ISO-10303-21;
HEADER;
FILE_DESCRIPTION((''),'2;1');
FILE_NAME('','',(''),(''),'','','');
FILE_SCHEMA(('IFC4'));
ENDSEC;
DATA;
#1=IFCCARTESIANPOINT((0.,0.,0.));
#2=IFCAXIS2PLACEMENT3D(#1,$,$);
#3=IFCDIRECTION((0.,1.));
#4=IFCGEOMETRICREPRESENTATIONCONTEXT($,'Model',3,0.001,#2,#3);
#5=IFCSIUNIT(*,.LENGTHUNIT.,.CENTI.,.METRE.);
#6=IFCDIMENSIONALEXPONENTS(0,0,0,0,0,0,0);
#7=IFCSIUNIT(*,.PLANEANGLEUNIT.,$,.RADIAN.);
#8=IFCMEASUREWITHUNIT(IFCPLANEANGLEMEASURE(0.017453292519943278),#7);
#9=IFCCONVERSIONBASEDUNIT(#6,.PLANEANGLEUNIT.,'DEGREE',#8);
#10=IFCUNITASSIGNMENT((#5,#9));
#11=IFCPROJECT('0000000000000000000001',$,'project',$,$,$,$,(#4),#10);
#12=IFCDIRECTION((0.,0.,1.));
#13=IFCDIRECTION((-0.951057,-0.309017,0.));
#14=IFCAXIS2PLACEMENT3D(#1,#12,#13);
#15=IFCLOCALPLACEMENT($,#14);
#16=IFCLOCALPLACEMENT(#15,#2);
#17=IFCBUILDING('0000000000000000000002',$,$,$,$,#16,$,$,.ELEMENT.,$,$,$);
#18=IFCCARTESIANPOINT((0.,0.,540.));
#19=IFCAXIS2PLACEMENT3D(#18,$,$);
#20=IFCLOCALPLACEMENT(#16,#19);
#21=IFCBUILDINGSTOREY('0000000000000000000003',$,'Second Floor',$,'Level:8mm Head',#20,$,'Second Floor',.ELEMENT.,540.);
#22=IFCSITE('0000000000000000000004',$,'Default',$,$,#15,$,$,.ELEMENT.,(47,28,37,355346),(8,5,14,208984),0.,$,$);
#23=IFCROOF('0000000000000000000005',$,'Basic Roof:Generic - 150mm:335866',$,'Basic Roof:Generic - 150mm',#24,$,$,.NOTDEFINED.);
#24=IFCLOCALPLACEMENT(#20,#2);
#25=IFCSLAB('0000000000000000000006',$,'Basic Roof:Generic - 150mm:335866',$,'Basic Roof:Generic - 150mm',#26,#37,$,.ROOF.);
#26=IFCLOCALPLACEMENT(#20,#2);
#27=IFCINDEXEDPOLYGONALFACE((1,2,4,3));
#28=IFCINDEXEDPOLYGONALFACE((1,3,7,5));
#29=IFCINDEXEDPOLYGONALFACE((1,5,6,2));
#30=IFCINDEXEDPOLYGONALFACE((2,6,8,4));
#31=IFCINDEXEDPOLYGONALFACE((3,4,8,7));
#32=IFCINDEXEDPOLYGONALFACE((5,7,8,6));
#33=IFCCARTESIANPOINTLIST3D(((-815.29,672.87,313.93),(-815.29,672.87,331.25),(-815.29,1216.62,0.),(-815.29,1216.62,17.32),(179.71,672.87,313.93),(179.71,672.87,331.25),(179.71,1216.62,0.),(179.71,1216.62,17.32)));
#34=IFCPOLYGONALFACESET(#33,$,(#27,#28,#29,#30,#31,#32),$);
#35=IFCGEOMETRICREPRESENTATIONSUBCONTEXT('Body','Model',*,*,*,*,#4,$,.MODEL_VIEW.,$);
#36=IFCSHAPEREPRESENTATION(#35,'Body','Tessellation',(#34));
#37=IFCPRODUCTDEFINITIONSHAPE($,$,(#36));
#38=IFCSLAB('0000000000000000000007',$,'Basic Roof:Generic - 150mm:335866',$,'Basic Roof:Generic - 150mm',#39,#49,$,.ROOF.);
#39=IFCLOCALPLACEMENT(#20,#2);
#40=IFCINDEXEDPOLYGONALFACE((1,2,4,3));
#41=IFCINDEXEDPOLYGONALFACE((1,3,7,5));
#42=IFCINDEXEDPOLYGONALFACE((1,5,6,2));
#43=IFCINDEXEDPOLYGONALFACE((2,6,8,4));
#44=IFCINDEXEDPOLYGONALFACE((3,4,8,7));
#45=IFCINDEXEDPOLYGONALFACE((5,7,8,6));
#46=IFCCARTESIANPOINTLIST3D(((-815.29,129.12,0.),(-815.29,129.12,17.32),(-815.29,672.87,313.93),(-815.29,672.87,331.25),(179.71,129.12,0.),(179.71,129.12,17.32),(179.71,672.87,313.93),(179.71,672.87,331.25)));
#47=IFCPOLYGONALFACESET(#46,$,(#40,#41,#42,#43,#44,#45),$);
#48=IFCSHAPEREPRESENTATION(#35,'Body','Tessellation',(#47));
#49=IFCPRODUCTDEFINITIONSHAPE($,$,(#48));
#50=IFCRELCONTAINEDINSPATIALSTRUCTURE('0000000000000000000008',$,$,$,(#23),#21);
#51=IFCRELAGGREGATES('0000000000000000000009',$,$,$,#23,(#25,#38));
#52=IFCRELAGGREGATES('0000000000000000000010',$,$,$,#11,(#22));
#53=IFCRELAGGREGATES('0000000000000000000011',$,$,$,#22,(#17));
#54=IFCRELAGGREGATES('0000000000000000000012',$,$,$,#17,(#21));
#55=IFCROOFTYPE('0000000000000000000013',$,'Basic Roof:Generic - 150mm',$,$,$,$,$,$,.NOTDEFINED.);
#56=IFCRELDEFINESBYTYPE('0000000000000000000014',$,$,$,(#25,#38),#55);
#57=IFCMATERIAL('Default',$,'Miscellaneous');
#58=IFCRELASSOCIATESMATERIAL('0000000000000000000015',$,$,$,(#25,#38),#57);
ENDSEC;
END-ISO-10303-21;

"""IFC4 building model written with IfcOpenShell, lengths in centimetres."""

from ifc_helpers import new_model, entity, si_unit, converted_unit, direction, frame, origin, place, context, subcontext, project, spatial, indexed_curve, outline, extrude, material, type_object, element, aggregate, save


model = new_model("IFC4")

# Units and contexts
model_context = context("Model", 3, precision=0.001, world=origin(), true_north=direction((0.0, 1.0)))
body_context = subcontext(model_context, "Body", "Model", "MODEL_VIEW")
ifc_project = project(units=[si_unit("LENGTHUNIT", "METRE", prefix="CENTI"), converted_unit("PLANEANGLEUNIT", "DEGREE", entity("IfcPlaneAngleMeasure", 0.017453292519943278), si_unit("PLANEANGLEUNIT", "RADIAN"), dimensions=[0, 0, 0, 0, 0, 0, 0])], contexts=[model_context])

# Site, building, storey
site_placement = place(None, frame((0.0, 0.0, 0.0), z_axis=(0.0, 0.0, 1.0), x_axis=(-0.951057, -0.309017, 0.0)))
site = spatial("IfcSite", under=ifc_project, at=site_placement, Name="Default", CompositionType="ELEMENT", RefLatitude=(47, 28, 37, 355346), RefLongitude=(8, 5, 14, 208984), RefElevation=0.0)
building_placement = place(site_placement, origin())
building = spatial("IfcBuilding", under=site, at=building_placement, CompositionType="ELEMENT")
storey_placement = place(building_placement, frame((0.0, 0.0, 540.0)))
storey = spatial("IfcBuildingStorey", under=building, at=storey_placement, Name="Second Floor", ObjectType="Level:8mm Head", LongName="Second Floor", CompositionType="ELEMENT", Elevation=540.0)

# Roof, slabs
roof_placement = place(storey_placement, frame((-815.29, 129.12, 0.0)))
roof = element("IfcRoof", 1, at=roof_placement, inside=storey, Name="Basic Roof:Generic - 150mm:335866", ObjectType="Basic Roof:Generic - 150mm", PredefinedType="NOTDEFINED")
ifc_material_1 = material(Name="Default", Category="Miscellaneous")
roof_type = type_object("IfcRoofType", Name="Basic Roof:Generic - 150mm", PredefinedType="NOTDEFINED")
slab_1_placement = place(roof_placement, origin())
slab_1 = element("IfcSlab", 2, at=slab_1_placement, type_object=roof_type, material=ifc_material_1, Name="Basic Roof:Generic - 150mm:335866", ObjectType="Basic Roof:Generic - 150mm", PredefinedType="ROOF", context=body_context, shape_type="SweptSolid", body=[
    extrude(outline(indexed_curve([(-497.5, -313.93), (497.5, -313.93), (497.5, 313.93), (-497.5, 313.93), (-497.5, -313.93)], self_intersect=False)), frame((497.5, 815.63, 156.97), z_axis=(0.0, 0.5, 0.866025), x_axis=(1.0, 0.0, 0.0)), (0.0, -0.5, 0.866025), 17.32),
])
slab_2_placement = place(roof_placement, origin())
slab_2 = element("IfcSlab", 3, at=slab_2_placement, type_object=roof_type, material=ifc_material_1, Name="Basic Roof:Generic - 150mm:335866", ObjectType="Basic Roof:Generic - 150mm", PredefinedType="ROOF", context=body_context, shape_type="SweptSolid", body=[
    extrude(outline(indexed_curve([(497.5, -313.93), (497.5, 313.93), (-497.5, 313.93), (-497.5, -313.93), (497.5, -313.93)], self_intersect=False)), frame((497.5, 271.88, 156.97), z_axis=(0.0, -0.5, 0.866025), x_axis=(1.0, 0.0, 0.0)), (0.0, 0.5, 0.866025), 17.32),
])
aggregate(roof, [slab_1, slab_2])

save(model, "model.ifc")
